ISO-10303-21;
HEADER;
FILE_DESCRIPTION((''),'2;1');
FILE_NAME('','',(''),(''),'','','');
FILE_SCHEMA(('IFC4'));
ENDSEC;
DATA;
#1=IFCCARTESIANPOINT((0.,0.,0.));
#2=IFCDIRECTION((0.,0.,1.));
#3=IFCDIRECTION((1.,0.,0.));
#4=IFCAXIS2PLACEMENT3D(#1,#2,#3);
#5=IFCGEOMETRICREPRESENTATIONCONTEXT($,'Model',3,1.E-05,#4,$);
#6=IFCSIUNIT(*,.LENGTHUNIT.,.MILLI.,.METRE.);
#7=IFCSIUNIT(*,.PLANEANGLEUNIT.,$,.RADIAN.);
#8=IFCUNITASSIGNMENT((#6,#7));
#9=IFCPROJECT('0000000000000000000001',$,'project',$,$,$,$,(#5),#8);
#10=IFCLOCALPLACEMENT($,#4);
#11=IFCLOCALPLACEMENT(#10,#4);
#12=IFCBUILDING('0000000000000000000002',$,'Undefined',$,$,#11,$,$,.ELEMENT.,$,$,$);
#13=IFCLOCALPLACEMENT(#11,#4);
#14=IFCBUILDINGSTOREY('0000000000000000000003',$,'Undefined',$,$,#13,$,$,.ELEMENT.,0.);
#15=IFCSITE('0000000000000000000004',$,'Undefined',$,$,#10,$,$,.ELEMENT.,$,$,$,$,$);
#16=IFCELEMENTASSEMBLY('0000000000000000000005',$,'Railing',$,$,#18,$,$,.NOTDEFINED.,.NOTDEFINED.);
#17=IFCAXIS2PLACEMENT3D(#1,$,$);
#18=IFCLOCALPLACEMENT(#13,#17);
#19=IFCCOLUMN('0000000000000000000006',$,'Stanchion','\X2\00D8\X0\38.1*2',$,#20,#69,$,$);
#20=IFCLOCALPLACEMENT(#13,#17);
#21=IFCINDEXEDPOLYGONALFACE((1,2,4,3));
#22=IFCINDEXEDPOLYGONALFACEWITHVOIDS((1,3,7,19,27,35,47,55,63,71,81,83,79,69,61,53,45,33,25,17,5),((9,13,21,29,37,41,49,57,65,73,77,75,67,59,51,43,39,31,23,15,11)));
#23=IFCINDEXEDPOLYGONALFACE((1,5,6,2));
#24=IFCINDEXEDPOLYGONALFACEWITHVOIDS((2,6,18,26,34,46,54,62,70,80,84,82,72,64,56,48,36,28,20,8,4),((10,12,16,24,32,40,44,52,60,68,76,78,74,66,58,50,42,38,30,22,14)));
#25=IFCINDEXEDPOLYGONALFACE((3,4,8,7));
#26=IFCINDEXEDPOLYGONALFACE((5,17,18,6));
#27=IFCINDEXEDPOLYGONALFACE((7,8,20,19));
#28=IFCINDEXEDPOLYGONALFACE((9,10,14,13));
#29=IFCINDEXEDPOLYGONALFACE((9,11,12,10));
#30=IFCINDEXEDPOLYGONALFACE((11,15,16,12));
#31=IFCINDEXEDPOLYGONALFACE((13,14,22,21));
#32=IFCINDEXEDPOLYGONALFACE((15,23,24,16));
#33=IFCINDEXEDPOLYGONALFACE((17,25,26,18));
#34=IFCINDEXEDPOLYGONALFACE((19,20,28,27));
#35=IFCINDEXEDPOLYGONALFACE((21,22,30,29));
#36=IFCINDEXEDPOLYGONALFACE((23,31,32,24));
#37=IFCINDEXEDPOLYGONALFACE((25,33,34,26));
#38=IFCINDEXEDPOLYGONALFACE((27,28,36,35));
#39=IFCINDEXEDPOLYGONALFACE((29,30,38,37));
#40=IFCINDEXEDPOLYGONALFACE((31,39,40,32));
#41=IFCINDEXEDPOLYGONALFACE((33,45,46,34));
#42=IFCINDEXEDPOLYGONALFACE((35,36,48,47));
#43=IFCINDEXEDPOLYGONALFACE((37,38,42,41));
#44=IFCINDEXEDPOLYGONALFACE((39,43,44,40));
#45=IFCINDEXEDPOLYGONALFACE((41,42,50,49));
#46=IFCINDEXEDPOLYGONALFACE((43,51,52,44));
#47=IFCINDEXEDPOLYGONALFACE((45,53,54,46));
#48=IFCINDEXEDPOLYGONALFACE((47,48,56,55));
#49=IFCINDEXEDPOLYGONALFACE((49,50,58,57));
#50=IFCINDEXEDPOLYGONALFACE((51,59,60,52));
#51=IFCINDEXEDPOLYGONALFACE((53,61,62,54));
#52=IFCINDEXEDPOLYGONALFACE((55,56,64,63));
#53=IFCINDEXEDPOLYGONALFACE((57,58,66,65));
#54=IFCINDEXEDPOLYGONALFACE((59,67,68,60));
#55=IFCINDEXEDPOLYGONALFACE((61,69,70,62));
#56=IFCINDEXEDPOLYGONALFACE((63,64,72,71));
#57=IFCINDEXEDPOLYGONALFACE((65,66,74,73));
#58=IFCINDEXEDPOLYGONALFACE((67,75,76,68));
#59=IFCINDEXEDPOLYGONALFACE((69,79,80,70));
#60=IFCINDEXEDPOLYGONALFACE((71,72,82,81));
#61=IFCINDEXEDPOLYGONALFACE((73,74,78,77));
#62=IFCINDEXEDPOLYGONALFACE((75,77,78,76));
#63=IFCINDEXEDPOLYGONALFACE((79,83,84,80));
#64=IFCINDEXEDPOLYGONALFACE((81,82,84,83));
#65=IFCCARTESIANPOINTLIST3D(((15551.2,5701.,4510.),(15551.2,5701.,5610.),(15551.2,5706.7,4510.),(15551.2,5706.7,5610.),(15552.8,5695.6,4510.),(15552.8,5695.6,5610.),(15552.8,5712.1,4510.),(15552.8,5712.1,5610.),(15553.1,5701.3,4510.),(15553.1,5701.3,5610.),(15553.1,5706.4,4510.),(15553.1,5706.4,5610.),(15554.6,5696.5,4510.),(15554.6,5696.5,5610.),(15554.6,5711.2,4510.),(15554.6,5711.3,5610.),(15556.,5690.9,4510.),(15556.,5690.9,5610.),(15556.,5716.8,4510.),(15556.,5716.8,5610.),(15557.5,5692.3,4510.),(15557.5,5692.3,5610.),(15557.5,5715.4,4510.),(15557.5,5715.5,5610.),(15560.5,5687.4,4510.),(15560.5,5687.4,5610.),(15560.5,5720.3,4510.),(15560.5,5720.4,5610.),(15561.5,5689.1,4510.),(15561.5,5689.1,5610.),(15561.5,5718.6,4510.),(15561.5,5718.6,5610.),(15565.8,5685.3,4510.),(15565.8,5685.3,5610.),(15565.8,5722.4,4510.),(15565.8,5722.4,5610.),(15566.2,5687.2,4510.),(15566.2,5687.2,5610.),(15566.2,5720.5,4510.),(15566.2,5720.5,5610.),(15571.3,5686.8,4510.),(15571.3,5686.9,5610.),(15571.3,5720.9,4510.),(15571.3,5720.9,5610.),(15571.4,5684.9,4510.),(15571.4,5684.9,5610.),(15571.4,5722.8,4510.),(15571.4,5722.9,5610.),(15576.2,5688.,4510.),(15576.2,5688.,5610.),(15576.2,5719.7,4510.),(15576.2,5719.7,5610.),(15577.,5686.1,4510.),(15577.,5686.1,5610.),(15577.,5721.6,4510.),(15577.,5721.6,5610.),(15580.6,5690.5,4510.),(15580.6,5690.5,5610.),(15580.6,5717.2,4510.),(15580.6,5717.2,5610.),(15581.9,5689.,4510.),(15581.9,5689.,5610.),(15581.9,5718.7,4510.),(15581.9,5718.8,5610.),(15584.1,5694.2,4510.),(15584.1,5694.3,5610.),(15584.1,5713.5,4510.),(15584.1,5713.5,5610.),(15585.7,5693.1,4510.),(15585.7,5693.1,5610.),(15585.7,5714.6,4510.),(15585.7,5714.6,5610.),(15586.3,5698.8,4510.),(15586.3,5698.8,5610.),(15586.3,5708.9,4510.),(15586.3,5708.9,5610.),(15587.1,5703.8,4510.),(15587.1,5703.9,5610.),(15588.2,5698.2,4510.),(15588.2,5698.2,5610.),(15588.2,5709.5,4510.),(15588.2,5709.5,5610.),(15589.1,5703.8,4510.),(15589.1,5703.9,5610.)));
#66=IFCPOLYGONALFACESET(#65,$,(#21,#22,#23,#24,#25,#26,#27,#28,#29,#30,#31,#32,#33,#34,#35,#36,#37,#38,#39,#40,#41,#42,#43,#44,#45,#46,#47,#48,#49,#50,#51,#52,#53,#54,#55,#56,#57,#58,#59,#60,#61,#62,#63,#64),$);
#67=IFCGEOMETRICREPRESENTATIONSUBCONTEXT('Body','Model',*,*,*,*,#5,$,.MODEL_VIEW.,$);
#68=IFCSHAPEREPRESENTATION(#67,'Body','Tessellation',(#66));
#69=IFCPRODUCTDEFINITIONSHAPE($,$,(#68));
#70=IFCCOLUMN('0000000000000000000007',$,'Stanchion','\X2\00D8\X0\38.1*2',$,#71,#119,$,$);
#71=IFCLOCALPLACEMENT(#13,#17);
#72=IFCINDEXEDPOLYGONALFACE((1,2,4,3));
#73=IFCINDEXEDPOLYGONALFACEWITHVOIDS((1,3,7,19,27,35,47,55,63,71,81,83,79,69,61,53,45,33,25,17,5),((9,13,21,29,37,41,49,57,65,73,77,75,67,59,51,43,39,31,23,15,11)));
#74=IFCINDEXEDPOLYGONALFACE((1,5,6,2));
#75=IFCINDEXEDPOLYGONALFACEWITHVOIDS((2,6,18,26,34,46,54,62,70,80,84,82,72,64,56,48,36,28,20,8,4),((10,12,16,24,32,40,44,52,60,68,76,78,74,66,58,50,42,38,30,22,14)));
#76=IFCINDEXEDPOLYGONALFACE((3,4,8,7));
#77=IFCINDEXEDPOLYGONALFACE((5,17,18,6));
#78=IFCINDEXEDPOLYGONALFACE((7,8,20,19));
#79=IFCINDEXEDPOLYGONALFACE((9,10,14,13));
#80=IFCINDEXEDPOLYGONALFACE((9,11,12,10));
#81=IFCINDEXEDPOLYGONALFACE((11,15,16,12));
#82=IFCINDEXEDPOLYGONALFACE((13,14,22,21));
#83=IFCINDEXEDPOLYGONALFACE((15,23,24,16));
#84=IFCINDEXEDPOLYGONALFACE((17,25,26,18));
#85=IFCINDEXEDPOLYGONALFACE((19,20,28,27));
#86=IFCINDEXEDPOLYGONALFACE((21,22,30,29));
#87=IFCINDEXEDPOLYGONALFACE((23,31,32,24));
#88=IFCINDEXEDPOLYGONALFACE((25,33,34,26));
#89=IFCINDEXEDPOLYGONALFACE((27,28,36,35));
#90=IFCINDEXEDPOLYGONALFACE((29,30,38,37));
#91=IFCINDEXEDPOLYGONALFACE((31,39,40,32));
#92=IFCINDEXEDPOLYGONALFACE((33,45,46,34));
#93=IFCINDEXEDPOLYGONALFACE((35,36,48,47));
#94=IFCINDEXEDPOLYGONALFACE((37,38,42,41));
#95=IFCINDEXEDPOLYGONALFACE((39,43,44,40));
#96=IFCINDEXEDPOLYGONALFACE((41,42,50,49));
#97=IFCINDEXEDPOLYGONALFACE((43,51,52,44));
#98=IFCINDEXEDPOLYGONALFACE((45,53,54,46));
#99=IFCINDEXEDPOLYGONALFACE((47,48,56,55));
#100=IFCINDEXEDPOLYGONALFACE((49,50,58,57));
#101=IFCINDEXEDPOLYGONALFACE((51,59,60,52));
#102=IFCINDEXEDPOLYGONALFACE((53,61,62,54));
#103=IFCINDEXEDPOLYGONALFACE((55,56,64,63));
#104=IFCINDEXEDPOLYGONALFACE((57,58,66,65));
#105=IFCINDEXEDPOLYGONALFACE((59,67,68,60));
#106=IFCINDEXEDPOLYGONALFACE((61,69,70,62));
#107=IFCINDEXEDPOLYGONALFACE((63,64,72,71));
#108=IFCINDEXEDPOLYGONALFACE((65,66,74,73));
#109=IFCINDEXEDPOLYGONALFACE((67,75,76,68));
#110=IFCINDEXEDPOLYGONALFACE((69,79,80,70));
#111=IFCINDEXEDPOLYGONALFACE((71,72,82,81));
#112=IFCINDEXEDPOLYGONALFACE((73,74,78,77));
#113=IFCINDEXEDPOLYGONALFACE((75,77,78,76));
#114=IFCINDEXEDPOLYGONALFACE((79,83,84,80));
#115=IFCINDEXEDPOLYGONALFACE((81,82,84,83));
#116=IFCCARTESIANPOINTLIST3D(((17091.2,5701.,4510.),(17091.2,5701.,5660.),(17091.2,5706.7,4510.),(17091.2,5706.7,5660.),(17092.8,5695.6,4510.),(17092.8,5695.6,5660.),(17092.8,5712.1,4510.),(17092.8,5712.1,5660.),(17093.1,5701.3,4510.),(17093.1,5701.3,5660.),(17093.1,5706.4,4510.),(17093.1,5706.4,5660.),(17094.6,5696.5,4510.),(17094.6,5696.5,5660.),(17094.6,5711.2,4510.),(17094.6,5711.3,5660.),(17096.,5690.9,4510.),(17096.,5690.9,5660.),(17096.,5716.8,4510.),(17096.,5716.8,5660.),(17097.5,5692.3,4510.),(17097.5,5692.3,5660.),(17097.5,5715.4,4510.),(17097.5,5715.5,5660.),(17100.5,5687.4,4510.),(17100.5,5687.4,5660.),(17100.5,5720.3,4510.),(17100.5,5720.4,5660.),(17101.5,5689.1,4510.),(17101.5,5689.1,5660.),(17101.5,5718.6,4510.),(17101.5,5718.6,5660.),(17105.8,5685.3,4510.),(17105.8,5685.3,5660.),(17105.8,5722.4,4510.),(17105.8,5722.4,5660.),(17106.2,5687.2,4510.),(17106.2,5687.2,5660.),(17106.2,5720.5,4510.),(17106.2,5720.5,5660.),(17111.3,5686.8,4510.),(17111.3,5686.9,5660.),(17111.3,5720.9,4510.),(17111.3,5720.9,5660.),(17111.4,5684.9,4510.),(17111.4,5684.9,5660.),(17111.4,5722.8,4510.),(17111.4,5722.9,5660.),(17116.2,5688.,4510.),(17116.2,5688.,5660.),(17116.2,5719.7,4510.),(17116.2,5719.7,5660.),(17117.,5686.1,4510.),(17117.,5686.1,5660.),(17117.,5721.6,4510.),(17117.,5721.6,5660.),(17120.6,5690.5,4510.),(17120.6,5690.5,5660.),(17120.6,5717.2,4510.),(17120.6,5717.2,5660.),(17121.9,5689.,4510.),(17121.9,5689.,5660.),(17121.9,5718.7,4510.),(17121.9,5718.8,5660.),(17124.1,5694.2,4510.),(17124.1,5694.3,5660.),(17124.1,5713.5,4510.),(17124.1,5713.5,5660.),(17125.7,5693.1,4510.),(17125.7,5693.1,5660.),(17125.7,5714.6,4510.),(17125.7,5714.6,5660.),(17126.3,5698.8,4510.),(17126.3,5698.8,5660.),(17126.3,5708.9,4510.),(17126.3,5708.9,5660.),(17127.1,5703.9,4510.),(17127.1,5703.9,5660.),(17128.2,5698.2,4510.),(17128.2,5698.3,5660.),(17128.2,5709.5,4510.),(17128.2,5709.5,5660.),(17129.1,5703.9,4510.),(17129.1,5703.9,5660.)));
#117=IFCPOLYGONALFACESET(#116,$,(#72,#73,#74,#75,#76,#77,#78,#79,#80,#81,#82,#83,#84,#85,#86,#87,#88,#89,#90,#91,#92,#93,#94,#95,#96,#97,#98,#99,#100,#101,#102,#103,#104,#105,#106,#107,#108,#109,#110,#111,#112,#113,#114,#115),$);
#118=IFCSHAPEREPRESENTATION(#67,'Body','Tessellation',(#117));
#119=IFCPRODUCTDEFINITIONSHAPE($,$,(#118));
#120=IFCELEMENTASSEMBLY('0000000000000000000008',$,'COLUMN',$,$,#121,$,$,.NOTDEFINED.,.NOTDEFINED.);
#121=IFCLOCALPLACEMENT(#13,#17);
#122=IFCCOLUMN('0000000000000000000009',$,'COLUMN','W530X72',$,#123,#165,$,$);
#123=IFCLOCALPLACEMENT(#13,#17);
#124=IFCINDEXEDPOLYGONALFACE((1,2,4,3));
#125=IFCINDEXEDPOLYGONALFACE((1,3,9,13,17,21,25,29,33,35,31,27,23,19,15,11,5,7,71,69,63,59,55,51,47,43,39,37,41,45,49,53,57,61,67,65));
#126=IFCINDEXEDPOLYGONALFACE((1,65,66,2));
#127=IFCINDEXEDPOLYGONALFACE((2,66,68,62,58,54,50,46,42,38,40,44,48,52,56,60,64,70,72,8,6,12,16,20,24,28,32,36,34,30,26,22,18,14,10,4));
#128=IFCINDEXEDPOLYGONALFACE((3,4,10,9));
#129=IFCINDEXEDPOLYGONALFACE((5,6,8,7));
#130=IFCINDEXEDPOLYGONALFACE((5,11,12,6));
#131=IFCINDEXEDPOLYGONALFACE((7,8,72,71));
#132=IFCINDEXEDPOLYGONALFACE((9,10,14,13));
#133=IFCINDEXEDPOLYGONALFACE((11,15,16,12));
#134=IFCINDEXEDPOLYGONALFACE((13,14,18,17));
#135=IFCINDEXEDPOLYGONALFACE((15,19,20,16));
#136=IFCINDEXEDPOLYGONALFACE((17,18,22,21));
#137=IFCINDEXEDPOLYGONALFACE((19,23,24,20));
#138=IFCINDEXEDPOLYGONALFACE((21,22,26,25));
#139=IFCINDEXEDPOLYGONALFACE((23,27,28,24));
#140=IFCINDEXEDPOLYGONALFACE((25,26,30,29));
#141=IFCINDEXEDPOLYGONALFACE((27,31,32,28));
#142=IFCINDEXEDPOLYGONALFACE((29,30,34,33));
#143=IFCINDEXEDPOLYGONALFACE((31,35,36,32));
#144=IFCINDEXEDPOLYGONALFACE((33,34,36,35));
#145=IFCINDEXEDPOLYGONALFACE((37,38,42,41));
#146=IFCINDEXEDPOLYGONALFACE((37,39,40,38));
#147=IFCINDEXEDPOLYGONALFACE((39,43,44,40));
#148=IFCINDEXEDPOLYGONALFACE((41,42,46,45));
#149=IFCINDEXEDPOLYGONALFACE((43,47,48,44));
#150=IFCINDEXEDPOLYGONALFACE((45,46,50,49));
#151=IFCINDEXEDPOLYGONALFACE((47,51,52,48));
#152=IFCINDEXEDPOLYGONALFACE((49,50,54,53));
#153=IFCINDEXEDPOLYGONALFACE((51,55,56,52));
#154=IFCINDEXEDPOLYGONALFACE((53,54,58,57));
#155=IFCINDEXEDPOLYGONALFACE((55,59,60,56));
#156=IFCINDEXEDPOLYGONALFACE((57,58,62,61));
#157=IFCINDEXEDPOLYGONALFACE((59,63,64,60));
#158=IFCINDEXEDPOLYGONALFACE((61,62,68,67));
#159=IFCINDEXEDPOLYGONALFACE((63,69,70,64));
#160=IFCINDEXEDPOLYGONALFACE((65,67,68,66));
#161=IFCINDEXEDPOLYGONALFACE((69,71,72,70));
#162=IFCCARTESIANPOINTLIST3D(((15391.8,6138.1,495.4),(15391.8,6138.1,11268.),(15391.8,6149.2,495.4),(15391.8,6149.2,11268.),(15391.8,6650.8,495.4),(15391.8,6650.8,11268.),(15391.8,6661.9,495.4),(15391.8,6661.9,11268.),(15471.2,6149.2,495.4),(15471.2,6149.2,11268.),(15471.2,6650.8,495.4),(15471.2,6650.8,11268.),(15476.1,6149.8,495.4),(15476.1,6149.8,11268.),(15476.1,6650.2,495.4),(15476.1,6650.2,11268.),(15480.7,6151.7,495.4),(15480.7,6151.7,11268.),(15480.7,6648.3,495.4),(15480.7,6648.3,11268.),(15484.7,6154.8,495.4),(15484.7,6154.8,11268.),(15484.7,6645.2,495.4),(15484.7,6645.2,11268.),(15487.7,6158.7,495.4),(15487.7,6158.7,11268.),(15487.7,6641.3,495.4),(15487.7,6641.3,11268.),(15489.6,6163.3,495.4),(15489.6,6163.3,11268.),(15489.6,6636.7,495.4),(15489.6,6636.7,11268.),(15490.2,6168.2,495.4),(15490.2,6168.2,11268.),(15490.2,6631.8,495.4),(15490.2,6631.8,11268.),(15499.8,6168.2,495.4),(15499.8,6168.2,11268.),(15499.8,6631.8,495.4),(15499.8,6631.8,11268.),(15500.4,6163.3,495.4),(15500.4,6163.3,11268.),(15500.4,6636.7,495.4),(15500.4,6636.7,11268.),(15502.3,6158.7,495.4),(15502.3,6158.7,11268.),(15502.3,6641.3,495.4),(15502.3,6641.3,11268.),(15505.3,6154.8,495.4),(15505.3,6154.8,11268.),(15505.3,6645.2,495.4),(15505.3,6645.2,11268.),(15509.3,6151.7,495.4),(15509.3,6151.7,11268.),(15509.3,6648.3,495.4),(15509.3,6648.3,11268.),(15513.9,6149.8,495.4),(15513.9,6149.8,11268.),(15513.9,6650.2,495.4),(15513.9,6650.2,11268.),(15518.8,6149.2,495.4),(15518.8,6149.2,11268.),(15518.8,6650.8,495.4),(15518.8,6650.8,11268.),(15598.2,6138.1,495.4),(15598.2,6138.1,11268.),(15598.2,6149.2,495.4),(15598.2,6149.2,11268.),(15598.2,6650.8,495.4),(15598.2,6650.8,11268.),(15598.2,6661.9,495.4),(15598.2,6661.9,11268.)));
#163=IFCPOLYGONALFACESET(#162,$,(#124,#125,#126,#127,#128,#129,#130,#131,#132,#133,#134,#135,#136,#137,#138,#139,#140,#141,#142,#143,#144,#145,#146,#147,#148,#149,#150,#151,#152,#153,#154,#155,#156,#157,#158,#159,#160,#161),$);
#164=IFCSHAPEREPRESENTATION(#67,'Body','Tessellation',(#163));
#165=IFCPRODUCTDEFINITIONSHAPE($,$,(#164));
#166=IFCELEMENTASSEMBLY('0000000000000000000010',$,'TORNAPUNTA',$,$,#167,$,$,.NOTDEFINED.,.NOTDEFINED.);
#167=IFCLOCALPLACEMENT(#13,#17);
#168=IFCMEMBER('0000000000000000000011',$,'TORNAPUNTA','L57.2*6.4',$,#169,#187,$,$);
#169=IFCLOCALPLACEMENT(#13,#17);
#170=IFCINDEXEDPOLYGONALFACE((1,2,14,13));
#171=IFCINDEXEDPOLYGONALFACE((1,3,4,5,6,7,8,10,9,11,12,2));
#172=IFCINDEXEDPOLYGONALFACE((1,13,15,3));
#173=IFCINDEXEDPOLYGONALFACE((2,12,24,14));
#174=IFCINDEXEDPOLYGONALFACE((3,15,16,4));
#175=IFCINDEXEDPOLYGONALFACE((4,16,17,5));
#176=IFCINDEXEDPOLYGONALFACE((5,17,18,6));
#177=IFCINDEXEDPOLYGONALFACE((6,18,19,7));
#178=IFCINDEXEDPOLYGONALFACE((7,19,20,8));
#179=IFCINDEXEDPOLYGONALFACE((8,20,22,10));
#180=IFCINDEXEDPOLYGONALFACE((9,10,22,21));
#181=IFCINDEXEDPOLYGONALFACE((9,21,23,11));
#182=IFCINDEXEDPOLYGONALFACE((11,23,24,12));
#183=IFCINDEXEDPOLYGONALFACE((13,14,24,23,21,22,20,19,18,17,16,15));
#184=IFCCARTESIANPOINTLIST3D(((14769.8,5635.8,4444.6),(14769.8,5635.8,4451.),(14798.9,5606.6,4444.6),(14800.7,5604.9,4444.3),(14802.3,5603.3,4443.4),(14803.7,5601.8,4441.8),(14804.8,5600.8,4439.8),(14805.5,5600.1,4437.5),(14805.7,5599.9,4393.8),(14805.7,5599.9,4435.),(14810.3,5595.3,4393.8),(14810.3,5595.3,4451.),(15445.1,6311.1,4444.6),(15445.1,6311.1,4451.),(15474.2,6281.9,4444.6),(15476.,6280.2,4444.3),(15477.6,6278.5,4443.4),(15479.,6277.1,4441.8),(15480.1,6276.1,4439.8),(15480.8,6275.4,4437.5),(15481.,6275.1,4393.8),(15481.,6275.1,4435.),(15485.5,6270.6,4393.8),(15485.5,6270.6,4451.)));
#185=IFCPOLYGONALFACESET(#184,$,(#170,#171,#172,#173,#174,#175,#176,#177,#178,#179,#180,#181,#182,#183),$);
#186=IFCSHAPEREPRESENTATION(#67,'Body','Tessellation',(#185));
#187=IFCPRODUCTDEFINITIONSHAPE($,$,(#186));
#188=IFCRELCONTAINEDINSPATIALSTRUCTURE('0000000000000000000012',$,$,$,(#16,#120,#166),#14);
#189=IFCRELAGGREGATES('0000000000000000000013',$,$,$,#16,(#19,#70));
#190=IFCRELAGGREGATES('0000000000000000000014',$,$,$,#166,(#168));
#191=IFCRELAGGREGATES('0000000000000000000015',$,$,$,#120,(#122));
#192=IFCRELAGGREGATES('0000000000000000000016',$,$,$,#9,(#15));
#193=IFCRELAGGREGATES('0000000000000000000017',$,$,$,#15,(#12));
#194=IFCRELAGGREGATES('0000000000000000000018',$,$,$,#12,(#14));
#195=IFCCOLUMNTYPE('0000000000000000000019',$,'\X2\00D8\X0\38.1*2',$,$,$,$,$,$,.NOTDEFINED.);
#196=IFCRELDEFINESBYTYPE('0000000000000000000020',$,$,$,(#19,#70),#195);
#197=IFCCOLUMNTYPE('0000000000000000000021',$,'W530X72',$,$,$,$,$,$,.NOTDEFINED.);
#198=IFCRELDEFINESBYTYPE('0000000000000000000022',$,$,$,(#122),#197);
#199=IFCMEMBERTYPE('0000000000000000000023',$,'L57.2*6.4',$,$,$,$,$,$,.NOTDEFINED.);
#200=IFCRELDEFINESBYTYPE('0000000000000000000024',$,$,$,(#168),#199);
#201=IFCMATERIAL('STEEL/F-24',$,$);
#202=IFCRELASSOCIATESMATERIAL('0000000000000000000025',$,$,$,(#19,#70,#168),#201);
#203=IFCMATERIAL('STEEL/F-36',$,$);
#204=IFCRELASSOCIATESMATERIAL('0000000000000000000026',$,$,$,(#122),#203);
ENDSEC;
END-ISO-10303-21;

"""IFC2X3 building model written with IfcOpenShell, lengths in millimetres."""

from ifc_helpers import new_model, si_unit, frame, origin_with_axes, origin_2d_with_axis, place, context, subcontext, project, spatial, hollow_circle, i_section, l_section, extrude, clip, halfspace, material, type_object, element, aggregate, save


model = new_model("IFC2X3")

# Units and contexts
model_context = context("Model", 3, precision=1e-05, world=origin_with_axes())
body_context = subcontext(model_context, "Body", "Model", "MODEL_VIEW")
ifc_project = project(units=[si_unit("LENGTHUNIT", "METRE", prefix="MILLI"), si_unit("PLANEANGLEUNIT", "RADIAN")], contexts=[model_context])

# Site, building, storey
site_placement = place(None, origin_with_axes())
site = spatial("IfcSite", under=ifc_project, at=site_placement, Name="Undefined", CompositionType="ELEMENT")
building_placement = place(site_placement, origin_with_axes())
building = spatial("IfcBuilding", under=site, at=building_placement, Name="Undefined", CompositionType="ELEMENT")
storey_placement = place(building_placement, origin_with_axes())
storey = spatial("IfcBuildingStorey", under=building, at=storey_placement, Name="Undefined", CompositionType="ELEMENT", Elevation=0.0)

# Element assembly, columns
assembly_1_placement = place(storey_placement, origin_with_axes())
assembly_1 = element("IfcElementAssembly", 1, at=assembly_1_placement, inside=storey, Name="Railing", AssemblyPlace="NOTDEFINED", PredefinedType="NOTDEFINED")
ifc_material_1 = material(Name="STEEL/F-24")
column_type_1 = type_object("IfcColumnType", Name="Ø38.1*2", PredefinedType="NOTDEFINED")
column_1_placement = place(assembly_1_placement, frame((15570.0, 5703.8, 4510.0), z_axis=(0.0, 0.000014, 1.0), x_axis=(0.000001, -1.0, 0.000014)))
column_1 = element("IfcColumn", 2, at=column_1_placement, type_object=column_type_1, material=ifc_material_1, Name="Stanchion", Description="Ø38.1*2", context=body_context, shape_type="SweptSolid", body=[
    extrude(hollow_circle(Radius=19.1, WallThickness=2.0, at=origin_2d_with_axis()), frame((0.0, 0.0, 1100.0), z_axis=(0.0, 0.0, -1.0), x_axis=(0.0, 1.0, 0.0)), (0.0, 0.0, 1.0), 1100.0),
])
column_2_placement = place(assembly_1_placement, frame((17110.0, 5703.9, 4510.0), z_axis=(0.0, 0.000014, 1.0), x_axis=(0.0, -1.0, 0.000014)))
column_2 = element("IfcColumn", 3, at=column_2_placement, type_object=column_type_1, material=ifc_material_1, Name="Stanchion", Description="Ø38.1*2", context=body_context, shape_type="SweptSolid", body=[
    extrude(hollow_circle(Radius=19.1, WallThickness=2.0, at=origin_2d_with_axis()), frame((0.0, 0.0, 1150.0), z_axis=(0.0, 0.0, -1.0), x_axis=(0.0, 1.0, 0.0)), (0.0, 0.0, 1.0), 1150.0),
])

# Element assembly, column
assembly_2_placement = place(storey_placement, origin_with_axes())
assembly_2 = element("IfcElementAssembly", 4, at=assembly_2_placement, inside=storey, Name="COLUMN", AssemblyPlace="NOTDEFINED", PredefinedType="NOTDEFINED")
ifc_material_2 = material(Name="STEEL/F-36")
column_type_2 = type_object("IfcColumnType", Name="W530X72", PredefinedType="NOTDEFINED")
column_3_placement = place(assembly_2_placement, frame((15495.0, 6400.0, 470.0), z_axis=(0.0, 0.0, 1.0), x_axis=(0.0, 1.0, 0.0)))
column_3 = element("IfcColumn", 5, at=column_3_placement, type_object=column_type_2, material=ifc_material_2, Name="COLUMN", Description="W530X72", context=body_context, shape_type="Clipping", body=[
    clip(extrude(i_section(OverallWidth=206.4, OverallDepth=523.9, WebThickness=9.5, FlangeThickness=11.1, FilletRadius=19.0, at=origin_2d_with_axis()), frame((0.0, 0.0, 10798.0), z_axis=(0.0, 0.0, -1.0), x_axis=(0.0, 1.0, 0.0)), (0.0, 0.0, 1.0), 10798.0), halfspace(frame((-261.9, 0.0, 25.4), z_axis=(0.0, 0.0, 1.0), x_axis=(0.0, 1.0, 0.0)), True)),
])

# Element assembly, member
assembly_3_placement = place(storey_placement, origin_with_axes())
assembly_3 = element("IfcElementAssembly", 6, at=assembly_3_placement, inside=storey, Name="TORNAPUNTA", AssemblyPlace="NOTDEFINED", PredefinedType="NOTDEFINED")
member_type_1 = type_object("IfcMemberType", Name="L57.2*6.4", PredefinedType="NOTDEFINED")
member_1_placement = place(assembly_3_placement, frame((15465.3, 6290.8, 4422.4), z_axis=(-0.707107, 0.707107, 0.0), x_axis=(-0.707107, -0.707107, 0.0)))
member_1 = element("IfcMember", 7, at=member_1_placement, type_object=member_type_1, material=ifc_material_1, Name="TORNAPUNTA", Description="L57.2*6.4", context=body_context, shape_type="SweptSolid", body=[
    extrude(l_section(Depth=57.2, Width=57.2, Thickness=6.4, FilletRadius=9.6, at=origin_2d_with_axis()), frame((955.0, 0.0, 0.0), z_axis=(-1.0, 0.0, 0.0), x_axis=(0.0, -1.0, 0.0)), (0.0, 0.0, 1.0), 955.0),
])

aggregate(assembly_1, [column_1, column_2])

aggregate(assembly_3, [member_1])

aggregate(assembly_2, [column_3])

save(model, "model.ifc")
